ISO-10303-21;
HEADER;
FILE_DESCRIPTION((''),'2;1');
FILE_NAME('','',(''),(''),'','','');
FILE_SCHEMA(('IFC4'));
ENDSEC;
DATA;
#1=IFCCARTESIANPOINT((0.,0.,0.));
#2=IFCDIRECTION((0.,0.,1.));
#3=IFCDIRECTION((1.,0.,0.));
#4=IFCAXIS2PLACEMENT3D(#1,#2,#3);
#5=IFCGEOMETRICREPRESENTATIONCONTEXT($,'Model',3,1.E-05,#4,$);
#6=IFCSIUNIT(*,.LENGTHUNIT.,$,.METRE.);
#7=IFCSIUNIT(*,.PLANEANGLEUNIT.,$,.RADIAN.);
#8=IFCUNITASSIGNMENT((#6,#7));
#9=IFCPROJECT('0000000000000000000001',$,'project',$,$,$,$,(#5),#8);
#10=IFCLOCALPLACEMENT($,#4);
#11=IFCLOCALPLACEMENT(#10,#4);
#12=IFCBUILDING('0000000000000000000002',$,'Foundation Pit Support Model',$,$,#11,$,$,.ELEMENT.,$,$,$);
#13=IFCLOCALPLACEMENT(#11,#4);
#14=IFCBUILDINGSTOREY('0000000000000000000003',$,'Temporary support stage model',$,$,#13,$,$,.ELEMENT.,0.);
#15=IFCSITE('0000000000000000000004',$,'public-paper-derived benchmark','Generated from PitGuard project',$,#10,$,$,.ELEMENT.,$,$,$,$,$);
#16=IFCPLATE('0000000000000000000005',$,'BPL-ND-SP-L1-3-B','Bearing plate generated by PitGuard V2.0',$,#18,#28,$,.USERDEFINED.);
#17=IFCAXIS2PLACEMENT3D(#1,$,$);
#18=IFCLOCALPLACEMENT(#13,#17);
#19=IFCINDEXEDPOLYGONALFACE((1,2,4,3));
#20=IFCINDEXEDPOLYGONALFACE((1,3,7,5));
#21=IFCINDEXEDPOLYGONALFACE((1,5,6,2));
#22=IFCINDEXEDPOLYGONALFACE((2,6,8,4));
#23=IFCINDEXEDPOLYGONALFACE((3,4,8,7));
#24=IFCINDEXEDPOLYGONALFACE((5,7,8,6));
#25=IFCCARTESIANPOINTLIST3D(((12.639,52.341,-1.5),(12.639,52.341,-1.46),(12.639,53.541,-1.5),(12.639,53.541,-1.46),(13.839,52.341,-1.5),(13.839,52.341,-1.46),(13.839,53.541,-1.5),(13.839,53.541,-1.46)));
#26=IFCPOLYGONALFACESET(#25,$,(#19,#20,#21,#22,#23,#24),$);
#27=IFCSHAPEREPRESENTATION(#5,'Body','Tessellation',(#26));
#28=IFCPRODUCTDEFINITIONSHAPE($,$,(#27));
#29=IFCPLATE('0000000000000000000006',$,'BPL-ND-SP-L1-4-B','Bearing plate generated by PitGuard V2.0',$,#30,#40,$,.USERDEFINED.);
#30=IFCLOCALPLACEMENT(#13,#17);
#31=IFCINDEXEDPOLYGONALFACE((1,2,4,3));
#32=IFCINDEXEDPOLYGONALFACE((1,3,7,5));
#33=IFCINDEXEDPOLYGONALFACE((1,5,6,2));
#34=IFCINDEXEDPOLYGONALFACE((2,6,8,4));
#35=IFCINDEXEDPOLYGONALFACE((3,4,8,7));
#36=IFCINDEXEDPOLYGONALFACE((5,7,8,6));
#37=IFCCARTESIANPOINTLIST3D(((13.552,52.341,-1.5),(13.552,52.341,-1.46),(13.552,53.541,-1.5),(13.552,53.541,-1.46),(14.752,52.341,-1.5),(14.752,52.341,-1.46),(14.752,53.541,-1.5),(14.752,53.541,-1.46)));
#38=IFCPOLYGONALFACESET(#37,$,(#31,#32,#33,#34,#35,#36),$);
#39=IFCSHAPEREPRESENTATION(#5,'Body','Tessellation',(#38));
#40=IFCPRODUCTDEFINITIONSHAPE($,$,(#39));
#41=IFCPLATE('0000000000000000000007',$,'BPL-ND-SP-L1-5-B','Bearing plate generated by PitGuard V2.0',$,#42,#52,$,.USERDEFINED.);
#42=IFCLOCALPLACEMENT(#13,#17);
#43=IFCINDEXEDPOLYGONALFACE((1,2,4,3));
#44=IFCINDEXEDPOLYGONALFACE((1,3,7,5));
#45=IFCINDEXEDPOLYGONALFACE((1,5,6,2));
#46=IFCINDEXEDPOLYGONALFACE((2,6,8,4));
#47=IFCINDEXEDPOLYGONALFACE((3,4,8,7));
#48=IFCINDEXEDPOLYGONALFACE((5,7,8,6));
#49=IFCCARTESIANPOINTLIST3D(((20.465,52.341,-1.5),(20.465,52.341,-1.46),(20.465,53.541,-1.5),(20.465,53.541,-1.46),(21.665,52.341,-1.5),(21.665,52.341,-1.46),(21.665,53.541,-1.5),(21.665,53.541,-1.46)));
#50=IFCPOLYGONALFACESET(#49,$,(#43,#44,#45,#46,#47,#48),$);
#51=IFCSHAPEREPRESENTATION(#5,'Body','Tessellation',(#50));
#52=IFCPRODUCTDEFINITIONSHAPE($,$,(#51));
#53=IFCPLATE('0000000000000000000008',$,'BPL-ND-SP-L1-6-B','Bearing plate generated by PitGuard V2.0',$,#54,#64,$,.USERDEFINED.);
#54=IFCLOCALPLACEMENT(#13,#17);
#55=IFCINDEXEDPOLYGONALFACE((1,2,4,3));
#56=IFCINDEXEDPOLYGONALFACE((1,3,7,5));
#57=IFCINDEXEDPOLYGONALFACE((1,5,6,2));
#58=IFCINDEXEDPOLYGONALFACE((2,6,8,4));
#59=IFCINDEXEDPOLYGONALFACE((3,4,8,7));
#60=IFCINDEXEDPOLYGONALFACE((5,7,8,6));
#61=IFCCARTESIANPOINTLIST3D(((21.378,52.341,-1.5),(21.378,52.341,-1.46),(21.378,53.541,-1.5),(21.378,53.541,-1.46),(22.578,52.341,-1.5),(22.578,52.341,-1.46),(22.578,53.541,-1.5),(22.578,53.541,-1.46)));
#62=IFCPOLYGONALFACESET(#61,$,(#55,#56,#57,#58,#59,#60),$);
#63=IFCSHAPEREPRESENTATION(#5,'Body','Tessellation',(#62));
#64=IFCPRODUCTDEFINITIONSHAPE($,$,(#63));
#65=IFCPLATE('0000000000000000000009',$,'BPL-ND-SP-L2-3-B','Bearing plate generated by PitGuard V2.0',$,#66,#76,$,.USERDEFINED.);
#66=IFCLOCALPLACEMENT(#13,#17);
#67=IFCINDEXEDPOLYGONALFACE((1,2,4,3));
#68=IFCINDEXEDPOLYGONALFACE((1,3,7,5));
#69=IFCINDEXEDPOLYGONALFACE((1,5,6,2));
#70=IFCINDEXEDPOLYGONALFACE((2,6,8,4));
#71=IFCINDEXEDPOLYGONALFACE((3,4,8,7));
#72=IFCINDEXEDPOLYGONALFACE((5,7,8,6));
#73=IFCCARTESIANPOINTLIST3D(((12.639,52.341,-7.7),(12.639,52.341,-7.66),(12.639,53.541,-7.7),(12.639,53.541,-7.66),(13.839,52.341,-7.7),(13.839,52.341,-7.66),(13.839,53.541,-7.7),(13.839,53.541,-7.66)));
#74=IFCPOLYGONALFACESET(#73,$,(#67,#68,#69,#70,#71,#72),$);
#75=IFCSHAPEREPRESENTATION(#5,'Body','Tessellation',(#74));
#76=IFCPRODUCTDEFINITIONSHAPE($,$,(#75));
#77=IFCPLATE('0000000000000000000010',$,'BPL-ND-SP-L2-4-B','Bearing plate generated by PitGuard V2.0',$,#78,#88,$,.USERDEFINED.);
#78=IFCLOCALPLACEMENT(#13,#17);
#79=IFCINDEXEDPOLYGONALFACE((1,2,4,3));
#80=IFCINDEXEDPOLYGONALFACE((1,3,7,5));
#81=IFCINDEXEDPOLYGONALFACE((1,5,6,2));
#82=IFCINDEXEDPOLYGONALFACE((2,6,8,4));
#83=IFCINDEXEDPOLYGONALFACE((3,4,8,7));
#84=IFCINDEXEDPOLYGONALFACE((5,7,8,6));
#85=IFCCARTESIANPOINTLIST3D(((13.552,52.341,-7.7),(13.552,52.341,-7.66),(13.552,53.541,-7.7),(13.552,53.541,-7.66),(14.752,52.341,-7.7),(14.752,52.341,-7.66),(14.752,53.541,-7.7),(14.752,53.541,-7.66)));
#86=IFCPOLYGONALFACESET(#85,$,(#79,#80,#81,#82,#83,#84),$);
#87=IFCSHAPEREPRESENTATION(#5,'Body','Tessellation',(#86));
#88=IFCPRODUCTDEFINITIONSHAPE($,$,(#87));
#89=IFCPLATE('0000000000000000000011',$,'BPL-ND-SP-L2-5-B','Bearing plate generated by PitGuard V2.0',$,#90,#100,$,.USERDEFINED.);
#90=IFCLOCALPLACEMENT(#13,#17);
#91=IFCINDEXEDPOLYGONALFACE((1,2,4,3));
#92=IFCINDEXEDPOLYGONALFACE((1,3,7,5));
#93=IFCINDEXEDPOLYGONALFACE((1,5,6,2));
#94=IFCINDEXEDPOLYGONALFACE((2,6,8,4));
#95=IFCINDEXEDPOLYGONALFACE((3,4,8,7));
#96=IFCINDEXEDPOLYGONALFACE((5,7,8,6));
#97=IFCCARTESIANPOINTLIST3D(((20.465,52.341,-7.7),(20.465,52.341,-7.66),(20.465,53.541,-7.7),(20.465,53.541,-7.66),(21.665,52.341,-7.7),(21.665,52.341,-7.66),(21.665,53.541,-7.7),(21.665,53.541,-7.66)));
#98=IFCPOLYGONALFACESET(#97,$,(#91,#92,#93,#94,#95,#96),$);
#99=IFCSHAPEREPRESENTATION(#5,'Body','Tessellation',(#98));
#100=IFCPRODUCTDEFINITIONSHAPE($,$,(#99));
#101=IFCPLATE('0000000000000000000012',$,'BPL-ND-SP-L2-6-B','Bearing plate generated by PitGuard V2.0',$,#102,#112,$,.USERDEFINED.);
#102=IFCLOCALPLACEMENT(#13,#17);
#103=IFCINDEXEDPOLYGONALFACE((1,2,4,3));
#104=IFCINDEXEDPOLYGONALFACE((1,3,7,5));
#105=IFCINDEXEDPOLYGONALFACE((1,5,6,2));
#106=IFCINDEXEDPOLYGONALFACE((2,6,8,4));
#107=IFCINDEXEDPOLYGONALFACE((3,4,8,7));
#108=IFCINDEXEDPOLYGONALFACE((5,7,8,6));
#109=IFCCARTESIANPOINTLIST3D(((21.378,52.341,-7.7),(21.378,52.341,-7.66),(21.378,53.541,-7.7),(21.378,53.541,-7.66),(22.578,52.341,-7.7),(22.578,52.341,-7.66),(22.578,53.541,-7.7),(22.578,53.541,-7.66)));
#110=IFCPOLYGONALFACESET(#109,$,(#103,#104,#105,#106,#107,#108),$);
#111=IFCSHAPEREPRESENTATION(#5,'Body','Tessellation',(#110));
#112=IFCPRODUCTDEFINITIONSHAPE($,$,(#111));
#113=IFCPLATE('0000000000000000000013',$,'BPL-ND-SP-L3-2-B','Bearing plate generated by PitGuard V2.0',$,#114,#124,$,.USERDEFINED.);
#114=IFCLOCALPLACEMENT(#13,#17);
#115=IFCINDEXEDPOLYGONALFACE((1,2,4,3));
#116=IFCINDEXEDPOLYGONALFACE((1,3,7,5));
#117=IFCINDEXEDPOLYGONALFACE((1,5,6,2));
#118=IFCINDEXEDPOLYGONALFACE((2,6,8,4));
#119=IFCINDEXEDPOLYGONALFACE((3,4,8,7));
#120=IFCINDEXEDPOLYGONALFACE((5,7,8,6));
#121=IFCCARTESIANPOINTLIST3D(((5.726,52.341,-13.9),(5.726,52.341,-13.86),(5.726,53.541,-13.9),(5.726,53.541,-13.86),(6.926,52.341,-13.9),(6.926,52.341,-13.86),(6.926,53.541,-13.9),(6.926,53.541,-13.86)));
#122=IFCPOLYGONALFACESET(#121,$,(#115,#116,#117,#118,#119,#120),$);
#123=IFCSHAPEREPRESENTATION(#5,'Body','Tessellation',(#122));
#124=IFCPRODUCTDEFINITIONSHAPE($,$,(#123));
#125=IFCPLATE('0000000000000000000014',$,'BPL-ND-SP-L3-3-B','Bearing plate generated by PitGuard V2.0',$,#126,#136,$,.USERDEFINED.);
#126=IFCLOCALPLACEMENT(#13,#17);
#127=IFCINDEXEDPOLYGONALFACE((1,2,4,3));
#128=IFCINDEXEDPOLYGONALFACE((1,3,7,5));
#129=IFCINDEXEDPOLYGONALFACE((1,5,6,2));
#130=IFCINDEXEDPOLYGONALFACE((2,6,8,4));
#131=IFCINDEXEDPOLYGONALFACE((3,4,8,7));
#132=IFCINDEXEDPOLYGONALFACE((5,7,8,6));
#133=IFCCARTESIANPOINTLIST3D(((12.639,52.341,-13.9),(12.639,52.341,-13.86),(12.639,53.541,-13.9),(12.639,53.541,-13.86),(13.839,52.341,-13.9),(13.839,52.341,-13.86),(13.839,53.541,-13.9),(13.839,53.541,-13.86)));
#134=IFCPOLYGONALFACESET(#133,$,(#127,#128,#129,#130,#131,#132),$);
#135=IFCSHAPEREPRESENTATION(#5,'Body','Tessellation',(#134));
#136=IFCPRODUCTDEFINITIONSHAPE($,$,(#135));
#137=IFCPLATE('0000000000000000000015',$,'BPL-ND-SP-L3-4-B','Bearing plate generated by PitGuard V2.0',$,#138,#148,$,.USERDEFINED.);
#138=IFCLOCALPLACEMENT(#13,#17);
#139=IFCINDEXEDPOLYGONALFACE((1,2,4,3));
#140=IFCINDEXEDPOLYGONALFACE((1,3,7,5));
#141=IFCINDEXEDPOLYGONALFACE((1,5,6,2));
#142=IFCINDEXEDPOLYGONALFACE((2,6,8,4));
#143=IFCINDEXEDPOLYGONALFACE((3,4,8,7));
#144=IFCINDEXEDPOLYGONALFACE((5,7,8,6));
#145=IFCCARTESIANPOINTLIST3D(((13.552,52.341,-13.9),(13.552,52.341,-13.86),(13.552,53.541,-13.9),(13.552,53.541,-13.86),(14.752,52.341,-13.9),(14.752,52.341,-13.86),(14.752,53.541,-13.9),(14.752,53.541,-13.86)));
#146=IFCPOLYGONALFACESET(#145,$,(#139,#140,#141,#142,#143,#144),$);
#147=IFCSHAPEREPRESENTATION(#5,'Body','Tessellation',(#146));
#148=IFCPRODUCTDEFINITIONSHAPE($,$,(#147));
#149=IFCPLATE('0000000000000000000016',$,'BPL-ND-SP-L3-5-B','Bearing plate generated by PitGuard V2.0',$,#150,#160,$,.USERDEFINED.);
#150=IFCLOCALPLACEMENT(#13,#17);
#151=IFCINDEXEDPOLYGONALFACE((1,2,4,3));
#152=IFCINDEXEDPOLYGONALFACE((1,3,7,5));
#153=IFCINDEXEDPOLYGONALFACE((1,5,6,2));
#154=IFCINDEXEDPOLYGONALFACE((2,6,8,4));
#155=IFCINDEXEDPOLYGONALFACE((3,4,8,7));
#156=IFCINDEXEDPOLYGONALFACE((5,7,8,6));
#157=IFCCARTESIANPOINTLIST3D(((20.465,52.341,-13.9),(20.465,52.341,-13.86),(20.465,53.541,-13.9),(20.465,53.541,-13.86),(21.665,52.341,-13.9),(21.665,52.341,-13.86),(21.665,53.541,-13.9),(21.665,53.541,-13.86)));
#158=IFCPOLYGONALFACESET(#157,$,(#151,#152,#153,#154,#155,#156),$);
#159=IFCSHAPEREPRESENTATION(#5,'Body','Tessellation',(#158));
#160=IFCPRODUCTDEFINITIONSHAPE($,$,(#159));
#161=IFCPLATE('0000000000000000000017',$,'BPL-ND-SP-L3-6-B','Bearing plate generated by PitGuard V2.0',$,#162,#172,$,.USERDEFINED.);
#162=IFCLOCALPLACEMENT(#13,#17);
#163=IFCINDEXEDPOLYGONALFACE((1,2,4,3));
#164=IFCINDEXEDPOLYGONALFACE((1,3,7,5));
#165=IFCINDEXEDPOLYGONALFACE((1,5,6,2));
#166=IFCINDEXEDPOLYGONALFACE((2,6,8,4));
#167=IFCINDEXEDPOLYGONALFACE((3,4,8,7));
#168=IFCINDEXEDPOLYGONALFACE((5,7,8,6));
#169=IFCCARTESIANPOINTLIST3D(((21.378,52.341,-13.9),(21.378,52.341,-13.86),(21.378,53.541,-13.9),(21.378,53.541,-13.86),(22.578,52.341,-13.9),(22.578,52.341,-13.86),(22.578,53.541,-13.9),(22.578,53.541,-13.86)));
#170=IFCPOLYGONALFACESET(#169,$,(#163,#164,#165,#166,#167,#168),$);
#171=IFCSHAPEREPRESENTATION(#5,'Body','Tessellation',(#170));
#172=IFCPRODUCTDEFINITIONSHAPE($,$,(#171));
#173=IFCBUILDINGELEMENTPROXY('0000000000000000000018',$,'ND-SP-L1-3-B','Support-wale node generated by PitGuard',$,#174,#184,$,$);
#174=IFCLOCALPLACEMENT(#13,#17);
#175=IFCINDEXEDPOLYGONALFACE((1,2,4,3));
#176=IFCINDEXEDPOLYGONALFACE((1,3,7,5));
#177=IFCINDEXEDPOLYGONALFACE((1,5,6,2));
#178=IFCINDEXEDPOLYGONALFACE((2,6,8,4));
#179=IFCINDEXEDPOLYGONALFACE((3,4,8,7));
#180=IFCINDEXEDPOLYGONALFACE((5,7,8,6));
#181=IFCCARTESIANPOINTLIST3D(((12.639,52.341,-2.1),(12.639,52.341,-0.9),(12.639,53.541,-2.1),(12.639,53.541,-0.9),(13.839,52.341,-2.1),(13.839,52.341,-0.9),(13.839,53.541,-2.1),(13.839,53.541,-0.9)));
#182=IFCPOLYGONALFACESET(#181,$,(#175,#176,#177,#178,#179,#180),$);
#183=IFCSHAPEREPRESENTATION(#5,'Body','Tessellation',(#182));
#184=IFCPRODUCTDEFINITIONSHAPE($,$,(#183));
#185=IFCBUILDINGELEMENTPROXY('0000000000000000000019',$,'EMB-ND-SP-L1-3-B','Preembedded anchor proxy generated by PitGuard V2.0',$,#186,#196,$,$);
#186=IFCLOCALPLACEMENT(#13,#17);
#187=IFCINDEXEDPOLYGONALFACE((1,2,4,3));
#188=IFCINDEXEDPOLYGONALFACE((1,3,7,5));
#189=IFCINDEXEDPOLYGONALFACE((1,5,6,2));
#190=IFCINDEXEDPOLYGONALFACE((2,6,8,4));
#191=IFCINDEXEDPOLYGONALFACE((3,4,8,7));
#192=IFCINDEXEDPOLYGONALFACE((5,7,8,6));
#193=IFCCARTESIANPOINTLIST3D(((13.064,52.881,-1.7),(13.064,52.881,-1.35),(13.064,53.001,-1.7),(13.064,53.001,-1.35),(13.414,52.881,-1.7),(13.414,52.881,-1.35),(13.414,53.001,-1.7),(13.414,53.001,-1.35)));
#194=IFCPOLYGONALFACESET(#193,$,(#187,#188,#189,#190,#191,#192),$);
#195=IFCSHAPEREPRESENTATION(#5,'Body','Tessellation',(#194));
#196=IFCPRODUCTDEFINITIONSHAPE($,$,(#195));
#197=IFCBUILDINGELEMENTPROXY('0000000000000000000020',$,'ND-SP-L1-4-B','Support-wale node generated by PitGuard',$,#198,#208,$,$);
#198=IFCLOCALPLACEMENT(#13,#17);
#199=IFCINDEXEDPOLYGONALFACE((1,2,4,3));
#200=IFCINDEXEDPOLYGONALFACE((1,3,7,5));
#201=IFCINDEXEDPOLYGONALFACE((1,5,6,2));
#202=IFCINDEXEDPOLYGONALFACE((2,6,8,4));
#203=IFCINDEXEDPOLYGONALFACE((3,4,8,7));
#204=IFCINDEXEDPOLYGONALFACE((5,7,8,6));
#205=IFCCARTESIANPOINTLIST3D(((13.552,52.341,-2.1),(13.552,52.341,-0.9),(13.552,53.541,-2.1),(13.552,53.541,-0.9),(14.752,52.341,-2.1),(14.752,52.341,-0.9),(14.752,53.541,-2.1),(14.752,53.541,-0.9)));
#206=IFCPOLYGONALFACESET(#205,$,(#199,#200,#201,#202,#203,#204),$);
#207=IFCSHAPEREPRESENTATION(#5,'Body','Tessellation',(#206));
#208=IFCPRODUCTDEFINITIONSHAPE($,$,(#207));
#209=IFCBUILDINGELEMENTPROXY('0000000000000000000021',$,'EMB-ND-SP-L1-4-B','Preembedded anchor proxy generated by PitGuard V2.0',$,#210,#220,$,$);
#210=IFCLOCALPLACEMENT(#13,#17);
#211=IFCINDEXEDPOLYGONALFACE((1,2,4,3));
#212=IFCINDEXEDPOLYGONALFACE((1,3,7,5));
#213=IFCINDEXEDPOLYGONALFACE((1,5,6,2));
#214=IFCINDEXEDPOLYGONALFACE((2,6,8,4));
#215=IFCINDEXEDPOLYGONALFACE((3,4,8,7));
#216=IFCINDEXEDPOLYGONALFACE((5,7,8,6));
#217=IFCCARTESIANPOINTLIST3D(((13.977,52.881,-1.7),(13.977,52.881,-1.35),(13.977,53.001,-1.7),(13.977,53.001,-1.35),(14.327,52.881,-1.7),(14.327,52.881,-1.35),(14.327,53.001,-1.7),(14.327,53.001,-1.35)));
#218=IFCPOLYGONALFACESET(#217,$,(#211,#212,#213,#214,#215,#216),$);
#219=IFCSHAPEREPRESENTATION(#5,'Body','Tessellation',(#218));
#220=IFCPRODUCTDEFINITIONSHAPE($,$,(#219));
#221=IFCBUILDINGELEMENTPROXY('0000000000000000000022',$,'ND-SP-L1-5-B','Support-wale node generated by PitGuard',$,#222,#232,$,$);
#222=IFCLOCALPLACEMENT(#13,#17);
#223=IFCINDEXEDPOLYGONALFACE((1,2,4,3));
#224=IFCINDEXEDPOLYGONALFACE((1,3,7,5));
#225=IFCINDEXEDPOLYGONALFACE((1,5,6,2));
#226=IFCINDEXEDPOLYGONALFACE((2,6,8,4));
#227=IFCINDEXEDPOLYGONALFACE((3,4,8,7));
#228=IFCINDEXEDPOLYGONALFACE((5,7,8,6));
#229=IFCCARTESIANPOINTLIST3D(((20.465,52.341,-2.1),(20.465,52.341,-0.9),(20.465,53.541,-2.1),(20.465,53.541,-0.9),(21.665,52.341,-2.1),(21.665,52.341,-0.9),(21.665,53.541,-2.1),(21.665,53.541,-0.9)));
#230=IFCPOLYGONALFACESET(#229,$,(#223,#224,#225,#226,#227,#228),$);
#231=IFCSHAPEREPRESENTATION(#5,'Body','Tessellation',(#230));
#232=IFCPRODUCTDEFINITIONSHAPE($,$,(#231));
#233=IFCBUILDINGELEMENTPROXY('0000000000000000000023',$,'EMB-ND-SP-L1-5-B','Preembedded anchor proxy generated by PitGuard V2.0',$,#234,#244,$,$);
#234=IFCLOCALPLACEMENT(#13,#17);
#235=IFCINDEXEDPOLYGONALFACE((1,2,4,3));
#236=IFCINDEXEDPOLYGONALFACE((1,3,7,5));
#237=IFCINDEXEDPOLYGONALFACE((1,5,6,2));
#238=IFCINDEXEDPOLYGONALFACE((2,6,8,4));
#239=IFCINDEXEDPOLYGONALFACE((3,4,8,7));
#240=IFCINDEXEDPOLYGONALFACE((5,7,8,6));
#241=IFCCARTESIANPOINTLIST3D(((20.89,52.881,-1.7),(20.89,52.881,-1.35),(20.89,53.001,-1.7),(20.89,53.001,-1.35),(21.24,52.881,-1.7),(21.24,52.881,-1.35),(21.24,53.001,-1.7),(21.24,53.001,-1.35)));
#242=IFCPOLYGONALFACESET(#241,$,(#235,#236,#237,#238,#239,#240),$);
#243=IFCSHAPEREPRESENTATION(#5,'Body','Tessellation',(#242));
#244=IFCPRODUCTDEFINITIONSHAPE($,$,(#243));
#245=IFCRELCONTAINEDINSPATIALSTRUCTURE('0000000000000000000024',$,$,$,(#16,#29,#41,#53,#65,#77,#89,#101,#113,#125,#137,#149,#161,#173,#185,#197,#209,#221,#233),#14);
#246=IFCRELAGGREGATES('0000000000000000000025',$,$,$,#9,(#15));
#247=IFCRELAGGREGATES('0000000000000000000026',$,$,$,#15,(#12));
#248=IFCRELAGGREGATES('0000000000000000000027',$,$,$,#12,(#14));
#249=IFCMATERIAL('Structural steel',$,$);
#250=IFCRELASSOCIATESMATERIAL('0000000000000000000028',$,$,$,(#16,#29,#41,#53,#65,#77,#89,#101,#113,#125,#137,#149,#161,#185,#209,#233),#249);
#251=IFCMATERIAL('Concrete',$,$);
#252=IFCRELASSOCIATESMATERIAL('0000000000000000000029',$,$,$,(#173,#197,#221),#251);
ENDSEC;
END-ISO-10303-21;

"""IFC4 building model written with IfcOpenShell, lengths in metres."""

from ifc_helpers import new_model, si_unit, frame, origin_with_axes, origin_2d, place, context, project, spatial, rectangle, extrude, material, element, save


model = new_model("IFC4")

# Units and contexts
model_context = context("Model", 3, precision=1e-05, world=origin_with_axes())
ifc_project = project(units=[si_unit("LENGTHUNIT", "METRE"), si_unit("PLANEANGLEUNIT", "RADIAN")], contexts=[model_context])

# Site, building, storey
site_placement = place(None, origin_with_axes())
site = spatial("IfcSite", under=ifc_project, at=site_placement, Name="public-paper-derived benchmark", Description="Generated from PitGuard project", CompositionType="ELEMENT")
building_placement = place(site_placement, origin_with_axes())
building = spatial("IfcBuilding", under=site, at=building_placement, Name="Foundation Pit Support Model", CompositionType="ELEMENT")
storey_placement = place(building_placement, origin_with_axes())
storey = spatial("IfcBuildingStorey", under=building, at=storey_placement, Name="Temporary support stage model", CompositionType="ELEMENT", Elevation=0.0)

# Plates
ifc_material_1 = material(Name="Structural steel")
for number, where, z_axis, x_axis, name in (
    (1, (13.239, 52.941, -1.5), (0.0, 0.0, 1.0), (1.0, 0.0, 0.0), "BPL-ND-SP-L1-3-B"),
    (2, (14.152, 52.941, -1.5), (0.0, 0.0, 1.0), (1.0, 0.0, 0.0), "BPL-ND-SP-L1-4-B"),
    (3, (21.065, 52.941, -1.5), (0.0, 0.0, 1.0), (1.0, 0.0, 0.0), "BPL-ND-SP-L1-5-B"),
    (4, (21.978, 52.941, -1.5), (0.0, 0.0, 1.0), (1.0, 0.0, 0.0), "BPL-ND-SP-L1-6-B"),
    (5, (13.239, 52.941, -7.7), (0.0, 0.0, 1.0), (1.0, 0.0, 0.0), "BPL-ND-SP-L2-3-B"),
    (6, (14.152, 52.941, -7.7), (0.0, 0.0, 1.0), (1.0, 0.0, 0.0), "BPL-ND-SP-L2-4-B"),
    (7, (21.065, 52.941, -7.7), (0.0, 0.0, 1.0), (1.0, 0.0, 0.0), "BPL-ND-SP-L2-5-B"),
    (8, (21.978, 52.941, -7.7), (0.0, 0.0, 1.0), (1.0, 0.0, 0.0), "BPL-ND-SP-L2-6-B"),
    (9, (6.326, 52.941, -13.9), (0.0, 0.0, 1.0), (1.0, 0.0, 0.0), "BPL-ND-SP-L3-2-B"),
    (10, (13.239, 52.941, -13.9), (0.0, 0.0, 1.0), (1.0, 0.0, 0.0), "BPL-ND-SP-L3-3-B"),
    (11, (14.152, 52.941, -13.9), (0.0, 0.0, 1.0), (1.0, 0.0, 0.0), "BPL-ND-SP-L3-4-B"),
    (12, (21.065, 52.941, -13.9), (0.0, 0.0, 1.0), (1.0, 0.0, 0.0), "BPL-ND-SP-L3-5-B"),
    (13, (21.978, 52.941, -13.9), (0.0, 0.0, 1.0), (1.0, 0.0, 0.0), "BPL-ND-SP-L3-6-B"),
):
    element("IfcPlate", number, at=place(storey_placement, frame(where, z_axis=z_axis, x_axis=x_axis)), inside=storey, material=ifc_material_1, Name=name, Description="Bearing plate generated by PitGuard V2.0", PredefinedType="USERDEFINED", context=model_context, shape_type="SweptSolid", body=[
        extrude(rectangle(XDim=1.2, YDim=1.2, at=origin_2d()), origin_with_axes(), (0.0, 0.0, 1.0), 0.04),
    ])

# Building element proxies
ifc_material_2 = material(Name="Concrete")
proxy_1_placement = place(storey_placement, frame((13.239, 52.941, -2.1), z_axis=(0.0, 0.0, 1.0), x_axis=(1.0, 0.0, 0.0)))
element("IfcBuildingElementProxy", 14, at=proxy_1_placement, inside=storey, material=ifc_material_2, Name="ND-SP-L1-3-B", Description="Support-wale node generated by PitGuard", context=model_context, shape_type="SweptSolid", body=[
    extrude(rectangle(XDim=1.2, YDim=1.2, at=origin_2d()), origin_with_axes(), (0.0, 0.0, 1.0), 1.2),
])
proxy_2_placement = place(storey_placement, frame((13.239, 52.941, -1.7), z_axis=(0.0, 0.0, 1.0), x_axis=(1.0, 0.0, 0.0)))
element("IfcBuildingElementProxy", 15, at=proxy_2_placement, inside=storey, material=ifc_material_1, Name="EMB-ND-SP-L1-3-B", Description="Preembedded anchor proxy generated by PitGuard V2.0", context=model_context, shape_type="SweptSolid", body=[
    extrude(rectangle(XDim=0.35, YDim=0.12, at=origin_2d()), origin_with_axes(), (0.0, 0.0, 1.0), 0.35),
])
proxy_3_placement = place(storey_placement, frame((14.152, 52.941, -2.1), z_axis=(0.0, 0.0, 1.0), x_axis=(1.0, 0.0, 0.0)))
element("IfcBuildingElementProxy", 16, at=proxy_3_placement, inside=storey, material=ifc_material_2, Name="ND-SP-L1-4-B", Description="Support-wale node generated by PitGuard", context=model_context, shape_type="SweptSolid", body=[
    extrude(rectangle(XDim=1.2, YDim=1.2, at=origin_2d()), origin_with_axes(), (0.0, 0.0, 1.0), 1.2),
])
proxy_4_placement = place(storey_placement, frame((14.152, 52.941, -1.7), z_axis=(0.0, 0.0, 1.0), x_axis=(1.0, 0.0, 0.0)))
element("IfcBuildingElementProxy", 17, at=proxy_4_placement, inside=storey, material=ifc_material_1, Name="EMB-ND-SP-L1-4-B", Description="Preembedded anchor proxy generated by PitGuard V2.0", context=model_context, shape_type="SweptSolid", body=[
    extrude(rectangle(XDim=0.35, YDim=0.12, at=origin_2d()), origin_with_axes(), (0.0, 0.0, 1.0), 0.35),
])
proxy_5_placement = place(storey_placement, frame((21.065, 52.941, -2.1), z_axis=(0.0, 0.0, 1.0), x_axis=(1.0, 0.0, 0.0)))
element("IfcBuildingElementProxy", 18, at=proxy_5_placement, inside=storey, material=ifc_material_2, Name="ND-SP-L1-5-B", Description="Support-wale node generated by PitGuard", context=model_context, shape_type="SweptSolid", body=[
    extrude(rectangle(XDim=1.2, YDim=1.2, at=origin_2d()), origin_with_axes(), (0.0, 0.0, 1.0), 1.2),
])
proxy_6_placement = place(storey_placement, frame((21.065, 52.941, -1.7), z_axis=(0.0, 0.0, 1.0), x_axis=(1.0, 0.0, 0.0)))
element("IfcBuildingElementProxy", 19, at=proxy_6_placement, inside=storey, material=ifc_material_1, Name="EMB-ND-SP-L1-5-B", Description="Preembedded anchor proxy generated by PitGuard V2.0", context=model_context, shape_type="SweptSolid", body=[
    extrude(rectangle(XDim=0.35, YDim=0.12, at=origin_2d()), origin_with_axes(), (0.0, 0.0, 1.0), 0.35),
])

save(model, "model.ifc")
